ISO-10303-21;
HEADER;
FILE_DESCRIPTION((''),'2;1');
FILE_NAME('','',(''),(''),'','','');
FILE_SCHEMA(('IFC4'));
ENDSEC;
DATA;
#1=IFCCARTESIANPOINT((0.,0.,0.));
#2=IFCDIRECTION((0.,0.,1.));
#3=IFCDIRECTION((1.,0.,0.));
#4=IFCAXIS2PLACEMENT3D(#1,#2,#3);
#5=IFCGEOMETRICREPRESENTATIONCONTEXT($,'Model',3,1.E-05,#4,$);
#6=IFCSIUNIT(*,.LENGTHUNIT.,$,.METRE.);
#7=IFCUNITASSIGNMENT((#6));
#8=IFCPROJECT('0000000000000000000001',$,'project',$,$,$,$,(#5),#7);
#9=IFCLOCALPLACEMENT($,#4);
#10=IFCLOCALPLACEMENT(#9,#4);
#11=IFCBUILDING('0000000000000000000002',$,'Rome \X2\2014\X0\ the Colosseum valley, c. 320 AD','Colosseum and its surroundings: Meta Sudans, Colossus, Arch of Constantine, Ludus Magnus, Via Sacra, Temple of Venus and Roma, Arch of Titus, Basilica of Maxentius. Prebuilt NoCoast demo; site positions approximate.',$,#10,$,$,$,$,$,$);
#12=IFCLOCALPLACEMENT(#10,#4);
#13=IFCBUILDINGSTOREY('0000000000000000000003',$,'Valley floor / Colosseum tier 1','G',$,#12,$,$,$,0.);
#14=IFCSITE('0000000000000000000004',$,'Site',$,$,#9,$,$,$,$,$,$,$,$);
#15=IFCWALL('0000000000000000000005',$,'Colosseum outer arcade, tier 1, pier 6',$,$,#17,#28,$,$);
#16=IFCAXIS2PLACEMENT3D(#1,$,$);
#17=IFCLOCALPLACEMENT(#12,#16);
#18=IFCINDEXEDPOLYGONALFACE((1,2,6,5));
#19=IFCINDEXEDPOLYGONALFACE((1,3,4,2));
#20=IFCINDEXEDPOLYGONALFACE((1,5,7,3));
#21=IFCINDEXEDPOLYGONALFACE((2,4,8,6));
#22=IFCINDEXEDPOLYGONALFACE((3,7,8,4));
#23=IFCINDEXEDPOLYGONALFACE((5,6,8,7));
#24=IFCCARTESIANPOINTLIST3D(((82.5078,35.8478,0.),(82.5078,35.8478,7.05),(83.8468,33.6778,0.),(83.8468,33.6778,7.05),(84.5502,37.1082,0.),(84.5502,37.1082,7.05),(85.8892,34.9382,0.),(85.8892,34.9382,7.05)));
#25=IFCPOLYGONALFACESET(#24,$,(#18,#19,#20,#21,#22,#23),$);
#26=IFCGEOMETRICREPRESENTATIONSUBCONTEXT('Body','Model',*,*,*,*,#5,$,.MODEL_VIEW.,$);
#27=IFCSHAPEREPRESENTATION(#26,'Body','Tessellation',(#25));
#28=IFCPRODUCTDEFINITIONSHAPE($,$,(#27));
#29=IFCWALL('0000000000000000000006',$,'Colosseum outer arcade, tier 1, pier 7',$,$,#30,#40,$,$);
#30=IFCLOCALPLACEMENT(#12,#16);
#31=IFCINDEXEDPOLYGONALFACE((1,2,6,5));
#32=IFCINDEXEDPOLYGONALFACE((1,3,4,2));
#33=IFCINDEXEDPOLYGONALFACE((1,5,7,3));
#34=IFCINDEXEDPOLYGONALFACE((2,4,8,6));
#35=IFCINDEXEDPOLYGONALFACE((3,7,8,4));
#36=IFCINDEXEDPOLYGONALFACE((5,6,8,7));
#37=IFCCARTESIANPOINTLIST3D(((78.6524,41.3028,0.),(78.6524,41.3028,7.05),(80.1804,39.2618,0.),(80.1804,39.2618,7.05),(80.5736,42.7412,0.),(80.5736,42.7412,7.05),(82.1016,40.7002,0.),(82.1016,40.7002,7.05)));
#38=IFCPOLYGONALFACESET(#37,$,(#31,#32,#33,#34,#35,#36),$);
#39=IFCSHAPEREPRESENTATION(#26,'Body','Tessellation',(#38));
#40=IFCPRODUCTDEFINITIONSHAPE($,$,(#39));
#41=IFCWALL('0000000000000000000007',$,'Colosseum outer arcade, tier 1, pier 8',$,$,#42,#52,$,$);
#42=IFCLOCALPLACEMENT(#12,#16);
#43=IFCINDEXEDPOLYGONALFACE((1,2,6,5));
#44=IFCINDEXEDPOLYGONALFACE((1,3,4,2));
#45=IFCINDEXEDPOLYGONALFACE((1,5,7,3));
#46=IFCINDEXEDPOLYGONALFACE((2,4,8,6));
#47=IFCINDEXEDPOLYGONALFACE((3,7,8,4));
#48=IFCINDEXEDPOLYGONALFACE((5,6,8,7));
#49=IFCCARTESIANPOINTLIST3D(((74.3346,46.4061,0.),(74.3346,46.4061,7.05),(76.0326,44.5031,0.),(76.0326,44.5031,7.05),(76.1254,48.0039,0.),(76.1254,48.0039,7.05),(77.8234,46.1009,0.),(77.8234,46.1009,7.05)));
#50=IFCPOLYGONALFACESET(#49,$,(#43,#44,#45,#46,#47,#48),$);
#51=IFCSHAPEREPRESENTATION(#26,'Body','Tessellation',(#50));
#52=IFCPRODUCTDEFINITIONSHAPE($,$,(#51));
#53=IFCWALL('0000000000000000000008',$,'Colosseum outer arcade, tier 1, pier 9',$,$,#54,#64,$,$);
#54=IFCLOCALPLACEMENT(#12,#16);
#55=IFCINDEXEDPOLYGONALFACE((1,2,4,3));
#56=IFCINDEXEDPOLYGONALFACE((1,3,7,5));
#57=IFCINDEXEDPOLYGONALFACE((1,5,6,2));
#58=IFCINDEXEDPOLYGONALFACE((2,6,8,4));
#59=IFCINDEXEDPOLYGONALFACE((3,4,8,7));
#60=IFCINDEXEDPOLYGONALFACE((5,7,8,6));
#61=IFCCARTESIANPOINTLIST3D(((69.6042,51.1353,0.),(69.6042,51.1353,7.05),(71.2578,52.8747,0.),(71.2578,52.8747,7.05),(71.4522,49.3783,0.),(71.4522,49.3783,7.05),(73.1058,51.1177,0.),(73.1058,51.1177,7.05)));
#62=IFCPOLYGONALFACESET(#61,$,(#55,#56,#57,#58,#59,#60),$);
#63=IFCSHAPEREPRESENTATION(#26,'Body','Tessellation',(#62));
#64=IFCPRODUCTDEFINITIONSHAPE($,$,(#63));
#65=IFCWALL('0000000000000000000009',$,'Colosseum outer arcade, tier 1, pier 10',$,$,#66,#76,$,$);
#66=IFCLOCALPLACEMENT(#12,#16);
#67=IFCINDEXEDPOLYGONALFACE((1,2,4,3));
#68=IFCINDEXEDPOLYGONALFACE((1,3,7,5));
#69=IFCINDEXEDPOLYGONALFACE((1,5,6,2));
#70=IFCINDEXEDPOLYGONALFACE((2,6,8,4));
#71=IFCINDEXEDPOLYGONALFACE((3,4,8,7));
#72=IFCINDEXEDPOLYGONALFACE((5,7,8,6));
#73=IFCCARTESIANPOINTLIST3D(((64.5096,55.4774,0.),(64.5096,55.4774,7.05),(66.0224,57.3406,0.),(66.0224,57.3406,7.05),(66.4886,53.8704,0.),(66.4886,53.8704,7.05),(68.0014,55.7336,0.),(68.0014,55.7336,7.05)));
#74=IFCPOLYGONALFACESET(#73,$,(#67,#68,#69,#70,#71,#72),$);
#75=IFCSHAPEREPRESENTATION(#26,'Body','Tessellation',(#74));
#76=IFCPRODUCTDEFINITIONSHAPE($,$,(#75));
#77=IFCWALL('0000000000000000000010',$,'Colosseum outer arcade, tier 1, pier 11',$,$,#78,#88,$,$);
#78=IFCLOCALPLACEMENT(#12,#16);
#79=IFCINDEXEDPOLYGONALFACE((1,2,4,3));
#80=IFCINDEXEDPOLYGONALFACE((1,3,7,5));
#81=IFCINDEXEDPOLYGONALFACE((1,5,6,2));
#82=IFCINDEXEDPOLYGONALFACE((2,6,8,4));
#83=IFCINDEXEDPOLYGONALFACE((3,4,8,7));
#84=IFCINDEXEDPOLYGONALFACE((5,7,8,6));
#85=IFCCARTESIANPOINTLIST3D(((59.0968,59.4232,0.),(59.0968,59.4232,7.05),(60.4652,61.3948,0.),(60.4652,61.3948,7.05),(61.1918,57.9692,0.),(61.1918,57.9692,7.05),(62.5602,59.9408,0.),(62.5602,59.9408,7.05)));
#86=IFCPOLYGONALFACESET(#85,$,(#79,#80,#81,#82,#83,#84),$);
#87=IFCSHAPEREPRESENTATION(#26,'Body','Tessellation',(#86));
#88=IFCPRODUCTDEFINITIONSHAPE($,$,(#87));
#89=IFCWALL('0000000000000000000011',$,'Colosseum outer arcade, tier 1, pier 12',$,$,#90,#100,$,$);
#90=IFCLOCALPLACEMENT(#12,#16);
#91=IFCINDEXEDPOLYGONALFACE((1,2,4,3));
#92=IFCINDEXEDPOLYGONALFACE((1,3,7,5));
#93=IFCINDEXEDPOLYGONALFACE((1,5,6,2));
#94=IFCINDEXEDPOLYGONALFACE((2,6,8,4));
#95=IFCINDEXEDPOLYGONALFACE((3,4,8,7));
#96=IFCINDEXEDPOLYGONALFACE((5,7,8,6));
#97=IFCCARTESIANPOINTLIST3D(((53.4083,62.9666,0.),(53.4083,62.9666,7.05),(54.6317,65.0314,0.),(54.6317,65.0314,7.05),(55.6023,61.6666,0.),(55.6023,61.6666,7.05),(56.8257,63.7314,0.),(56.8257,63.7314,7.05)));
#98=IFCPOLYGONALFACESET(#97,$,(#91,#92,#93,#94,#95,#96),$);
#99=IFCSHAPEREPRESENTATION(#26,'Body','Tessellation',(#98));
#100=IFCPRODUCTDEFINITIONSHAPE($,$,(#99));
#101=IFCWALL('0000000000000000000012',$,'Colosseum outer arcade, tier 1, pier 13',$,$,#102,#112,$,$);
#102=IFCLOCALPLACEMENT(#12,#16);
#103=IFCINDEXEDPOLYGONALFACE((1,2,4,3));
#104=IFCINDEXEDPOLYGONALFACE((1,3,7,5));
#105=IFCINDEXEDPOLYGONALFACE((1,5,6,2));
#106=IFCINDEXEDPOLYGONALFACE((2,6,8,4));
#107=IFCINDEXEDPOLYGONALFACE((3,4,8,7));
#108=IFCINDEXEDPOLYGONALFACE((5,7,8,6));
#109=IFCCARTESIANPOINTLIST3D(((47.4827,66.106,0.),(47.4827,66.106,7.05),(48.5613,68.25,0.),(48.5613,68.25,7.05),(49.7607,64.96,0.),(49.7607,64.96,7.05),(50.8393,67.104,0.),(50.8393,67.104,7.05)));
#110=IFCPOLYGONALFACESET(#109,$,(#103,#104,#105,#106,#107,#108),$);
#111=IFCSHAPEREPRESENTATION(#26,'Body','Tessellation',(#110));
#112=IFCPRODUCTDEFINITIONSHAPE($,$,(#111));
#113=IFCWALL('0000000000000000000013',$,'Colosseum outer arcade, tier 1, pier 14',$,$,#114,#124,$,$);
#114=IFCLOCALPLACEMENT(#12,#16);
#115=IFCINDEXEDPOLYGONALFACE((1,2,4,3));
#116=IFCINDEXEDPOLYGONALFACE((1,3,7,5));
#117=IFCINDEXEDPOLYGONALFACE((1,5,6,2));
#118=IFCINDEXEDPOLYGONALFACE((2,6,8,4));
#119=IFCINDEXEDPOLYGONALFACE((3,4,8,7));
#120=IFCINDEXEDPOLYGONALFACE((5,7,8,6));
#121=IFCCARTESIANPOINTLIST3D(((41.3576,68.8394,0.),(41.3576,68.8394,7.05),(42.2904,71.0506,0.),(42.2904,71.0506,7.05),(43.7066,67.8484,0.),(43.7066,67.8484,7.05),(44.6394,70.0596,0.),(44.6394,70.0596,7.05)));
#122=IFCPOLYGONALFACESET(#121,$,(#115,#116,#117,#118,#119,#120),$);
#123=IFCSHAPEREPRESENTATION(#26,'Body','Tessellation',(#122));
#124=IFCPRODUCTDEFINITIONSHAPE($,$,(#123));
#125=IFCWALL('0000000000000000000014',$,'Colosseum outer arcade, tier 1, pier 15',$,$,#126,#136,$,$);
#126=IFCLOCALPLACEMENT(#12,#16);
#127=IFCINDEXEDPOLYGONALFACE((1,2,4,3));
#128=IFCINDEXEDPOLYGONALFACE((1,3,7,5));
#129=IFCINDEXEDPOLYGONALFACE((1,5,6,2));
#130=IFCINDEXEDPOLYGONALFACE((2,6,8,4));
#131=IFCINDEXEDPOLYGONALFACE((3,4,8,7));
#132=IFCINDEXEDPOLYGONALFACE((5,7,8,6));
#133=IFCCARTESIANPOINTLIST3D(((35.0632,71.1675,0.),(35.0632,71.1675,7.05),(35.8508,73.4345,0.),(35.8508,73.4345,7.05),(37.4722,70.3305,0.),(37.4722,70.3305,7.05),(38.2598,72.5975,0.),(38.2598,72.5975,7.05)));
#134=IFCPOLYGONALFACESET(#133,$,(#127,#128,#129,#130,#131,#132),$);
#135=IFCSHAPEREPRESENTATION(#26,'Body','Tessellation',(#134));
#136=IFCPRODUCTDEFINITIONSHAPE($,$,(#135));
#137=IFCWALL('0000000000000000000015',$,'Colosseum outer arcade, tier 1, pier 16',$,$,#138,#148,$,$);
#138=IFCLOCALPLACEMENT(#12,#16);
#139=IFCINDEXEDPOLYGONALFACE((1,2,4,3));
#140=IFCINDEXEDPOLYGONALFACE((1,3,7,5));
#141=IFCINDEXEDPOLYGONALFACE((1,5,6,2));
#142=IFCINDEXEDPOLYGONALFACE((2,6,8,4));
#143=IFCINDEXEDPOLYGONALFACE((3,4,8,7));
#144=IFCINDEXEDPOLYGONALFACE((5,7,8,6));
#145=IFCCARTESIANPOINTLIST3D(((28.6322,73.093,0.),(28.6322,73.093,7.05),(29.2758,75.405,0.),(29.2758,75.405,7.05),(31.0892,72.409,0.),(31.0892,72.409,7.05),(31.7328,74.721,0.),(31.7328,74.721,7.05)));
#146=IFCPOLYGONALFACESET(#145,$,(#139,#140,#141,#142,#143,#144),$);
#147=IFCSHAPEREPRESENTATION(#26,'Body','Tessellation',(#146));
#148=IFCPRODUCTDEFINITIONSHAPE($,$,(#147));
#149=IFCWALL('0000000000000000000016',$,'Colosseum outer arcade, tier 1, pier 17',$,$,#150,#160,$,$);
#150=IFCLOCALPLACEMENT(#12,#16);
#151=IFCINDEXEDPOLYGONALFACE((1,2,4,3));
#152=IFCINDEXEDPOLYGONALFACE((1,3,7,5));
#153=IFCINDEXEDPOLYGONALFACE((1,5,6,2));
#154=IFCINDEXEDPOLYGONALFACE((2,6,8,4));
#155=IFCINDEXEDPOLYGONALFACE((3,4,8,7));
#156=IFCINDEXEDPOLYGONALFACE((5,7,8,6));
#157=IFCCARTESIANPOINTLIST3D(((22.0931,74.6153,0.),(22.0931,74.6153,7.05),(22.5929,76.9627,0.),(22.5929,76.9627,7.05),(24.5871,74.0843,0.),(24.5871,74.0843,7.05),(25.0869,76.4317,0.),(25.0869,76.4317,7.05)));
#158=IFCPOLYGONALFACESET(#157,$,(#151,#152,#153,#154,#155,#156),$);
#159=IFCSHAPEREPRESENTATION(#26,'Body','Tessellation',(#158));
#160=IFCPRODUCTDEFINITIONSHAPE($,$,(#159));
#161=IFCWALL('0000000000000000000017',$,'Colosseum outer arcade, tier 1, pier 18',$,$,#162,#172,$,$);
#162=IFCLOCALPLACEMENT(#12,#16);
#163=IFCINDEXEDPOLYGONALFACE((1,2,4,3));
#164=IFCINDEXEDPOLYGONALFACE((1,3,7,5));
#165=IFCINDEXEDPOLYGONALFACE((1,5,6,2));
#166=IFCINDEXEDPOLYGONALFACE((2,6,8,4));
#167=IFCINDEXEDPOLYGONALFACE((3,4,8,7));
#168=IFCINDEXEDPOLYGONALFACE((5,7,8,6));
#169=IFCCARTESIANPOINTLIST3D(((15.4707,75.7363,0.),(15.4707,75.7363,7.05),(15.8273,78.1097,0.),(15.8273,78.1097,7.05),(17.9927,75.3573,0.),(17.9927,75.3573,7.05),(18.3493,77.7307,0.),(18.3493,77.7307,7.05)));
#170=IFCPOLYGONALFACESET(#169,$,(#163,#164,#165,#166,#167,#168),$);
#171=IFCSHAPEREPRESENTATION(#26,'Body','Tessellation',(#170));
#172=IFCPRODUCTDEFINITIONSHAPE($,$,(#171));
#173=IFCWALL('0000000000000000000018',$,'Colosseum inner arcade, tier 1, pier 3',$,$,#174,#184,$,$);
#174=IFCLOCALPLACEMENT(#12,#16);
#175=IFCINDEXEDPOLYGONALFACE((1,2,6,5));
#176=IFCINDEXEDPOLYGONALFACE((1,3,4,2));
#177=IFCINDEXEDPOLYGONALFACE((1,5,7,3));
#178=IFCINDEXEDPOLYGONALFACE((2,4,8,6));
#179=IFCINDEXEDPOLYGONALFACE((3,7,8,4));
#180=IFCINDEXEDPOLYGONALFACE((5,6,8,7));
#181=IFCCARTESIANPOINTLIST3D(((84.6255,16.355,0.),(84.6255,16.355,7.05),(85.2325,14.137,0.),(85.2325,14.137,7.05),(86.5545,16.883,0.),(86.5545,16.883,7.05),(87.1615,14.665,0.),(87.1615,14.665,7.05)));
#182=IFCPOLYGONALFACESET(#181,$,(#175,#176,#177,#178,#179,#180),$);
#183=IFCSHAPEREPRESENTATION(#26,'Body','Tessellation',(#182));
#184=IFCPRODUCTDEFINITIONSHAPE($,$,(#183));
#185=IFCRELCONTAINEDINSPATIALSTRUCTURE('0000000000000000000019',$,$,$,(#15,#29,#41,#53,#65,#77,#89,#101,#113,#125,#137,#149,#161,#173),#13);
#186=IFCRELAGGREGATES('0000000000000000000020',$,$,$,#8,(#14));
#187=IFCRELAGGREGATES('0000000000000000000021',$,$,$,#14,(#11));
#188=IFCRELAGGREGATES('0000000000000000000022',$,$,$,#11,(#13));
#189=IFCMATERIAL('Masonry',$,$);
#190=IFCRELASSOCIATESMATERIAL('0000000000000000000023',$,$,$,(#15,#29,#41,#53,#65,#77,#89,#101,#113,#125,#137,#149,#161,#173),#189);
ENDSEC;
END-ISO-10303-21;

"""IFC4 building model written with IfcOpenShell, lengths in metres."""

from ifc_helpers import new_model, si_unit, frame, origin_with_axes, place, context, subcontext, project, spatial, indexed_curve, outline, extrude, material, element, save


model = new_model("IFC4")

# Units and contexts
model_context = context("Model", 3, precision=1e-05, world=origin_with_axes())
body_context = subcontext(model_context, "Body", "Model", "MODEL_VIEW")
ifc_project = project(units=[si_unit("LENGTHUNIT", "METRE")], contexts=[model_context])

# Site, building, storey
site_placement = place(None, origin_with_axes())
site = spatial("IfcSite", under=ifc_project, at=site_placement, Name="Site")
building_placement = place(site_placement, origin_with_axes())
building = spatial("IfcBuilding", under=site, at=building_placement, Name="Rome — the Colosseum valley, c. 320 AD", Description="Colosseum and its surroundings: Meta Sudans, Colossus, Arch of Constantine, Ludus Magnus, Via Sacra, Temple of Venus and Roma, Arch of Titus, Basilica of Maxentius. Prebuilt NoCoast demo; site positions approximate.")
storey_placement = place(building_placement, origin_with_axes())
storey = spatial("IfcBuildingStorey", under=building, at=storey_placement, Name="Valley floor / Colosseum tier 1", Description="G", Elevation=0.0)

# Walls
ifc_material = material(Name="Masonry")
wall_1_placement = place(storey_placement, frame((84.868, 34.308, 0.0), z_axis=(0.0, 0.0, 1.0), x_axis=(-0.525125, 0.851025, 0.0)))
element("IfcWall", 1, at=wall_1_placement, inside=storey, material=ifc_material, Name="Colosseum outer arcade, tier 1, pier 6", context=body_context, shape_type="SweptSolid", body=[
    extrude(outline(indexed_curve([(0.0, 0.0), (0.0, 2.4), (2.5499, 2.4), (2.5499, 0.0), (0.0, 0.0)], self_intersect=False)), frame((0.0, -1.2, 0.0), z_axis=(0.0, 0.0, 1.0), x_axis=(1.0, 0.0, 0.0)), (0.0, 0.0, 1.0), 7.05),
])
wall_2_placement = place(storey_placement, frame((81.141, 39.981, 0.0), z_axis=(0.0, 0.0, 1.0), x_axis=(-0.599309, 0.800517, 0.0)))
element("IfcWall", 2, at=wall_2_placement, inside=storey, material=ifc_material, Name="Colosseum outer arcade, tier 1, pier 7", context=body_context, shape_type="SweptSolid", body=[
    extrude(outline(indexed_curve([(0.0, 0.0), (0.0, 2.4), (2.5496, 2.4), (2.5496, 0.0), (0.0, 0.0)], self_intersect=False)), frame((0.0, -1.2, 0.0), z_axis=(0.0, 0.0, 1.0), x_axis=(1.0, 0.0, 0.0)), (0.0, 0.0, 1.0), 7.05),
])
wall_3_placement = place(storey_placement, frame((76.928, 45.302, 0.0), z_axis=(0.0, 0.0, 1.0), x_axis=(-0.665774, 0.746153, 0.0)))
element("IfcWall", 3, at=wall_3_placement, inside=storey, material=ifc_material, Name="Colosseum outer arcade, tier 1, pier 8", context=body_context, shape_type="SweptSolid", body=[
    extrude(outline(indexed_curve([(0.0, 0.0), (0.0, 2.4), (2.5504, 2.4), (2.5504, 0.0), (0.0, 0.0)], self_intersect=False)), frame((0.0, -1.2, 0.0), z_axis=(0.0, 0.0, 1.0), x_axis=(1.0, 0.0, 0.0)), (0.0, 0.0, 1.0), 7.05),
])
wall_4_placement = place(storey_placement, frame((72.279, 50.248, 0.0), z_axis=(0.0, 0.0, 1.0), x_axis=(-0.724725, 0.689038, 0.0)))
element("IfcWall", 4, at=wall_4_placement, inside=storey, material=ifc_material, Name="Colosseum outer arcade, tier 1, pier 9", context=body_context, shape_type="SweptSolid", body=[
    extrude(outline(indexed_curve([(0.0, 0.0), (0.0, 2.4), (2.5499, 2.4), (2.5499, 0.0), (0.0, 0.0)], self_intersect=False)), frame((0.0, -1.2, 0.0), z_axis=(0.0, 0.0, 1.0), x_axis=(1.0, 0.0, 0.0)), (0.0, 0.0, 1.0), 7.05),
])
wall_5_placement = place(storey_placement, frame((67.245, 54.802, 0.0), z_axis=(0.0, 0.0, 1.0), x_axis=(-0.776294, 0.630371, 0.0)))
element("IfcWall", 5, at=wall_5_placement, inside=storey, material=ifc_material, Name="Colosseum outer arcade, tier 1, pier 10", context=body_context, shape_type="SweptSolid", body=[
    extrude(outline(indexed_curve([(0.0, 0.0), (0.0, 2.4), (2.5493, 2.4), (2.5493, 0.0), (0.0, 0.0)], self_intersect=False)), frame((0.0, -1.2, 0.0), z_axis=(0.0, 0.0, 1.0), x_axis=(1.0, 0.0, 0.0)), (0.0, 0.0, 1.0), 7.05),
])
wall_6_placement = place(storey_placement, frame((61.876, 58.955, 0.0), z_axis=(0.0, 0.0, 1.0), x_axis=(-0.821528, 0.570168, 0.0)))
element("IfcWall", 6, at=wall_6_placement, inside=storey, material=ifc_material, Name="Colosseum outer arcade, tier 1, pier 11", context=body_context, shape_type="SweptSolid", body=[
    extrude(outline(indexed_curve([(0.0, 0.0), (0.0, 2.4), (2.5501, 2.4), (2.5501, 0.0), (0.0, 0.0)], self_intersect=False)), frame((0.0, -1.2, 0.0), z_axis=(0.0, 0.0, 1.0), x_axis=(1.0, 0.0, 0.0)), (0.0, 0.0, 1.0), 7.05),
])
wall_7_placement = place(storey_placement, frame((56.214, 62.699, 0.0), z_axis=(0.0, 0.0, 1.0), x_axis=(-0.860317, 0.509759, 0.0)))
element("IfcWall", 7, at=wall_7_placement, inside=storey, material=ifc_material, Name="Colosseum outer arcade, tier 1, pier 12", context=body_context, shape_type="SweptSolid", body=[
    extrude(outline(indexed_curve([(0.0, 0.0), (0.0, 2.4), (2.5502, 2.4), (2.5502, 0.0), (0.0, 0.0)], self_intersect=False)), frame((0.0, -1.2, 0.0), z_axis=(0.0, 0.0, 1.0), x_axis=(1.0, 0.0, 0.0)), (0.0, 0.0, 1.0), 7.05),
])
wall_8_placement = place(storey_placement, frame((50.3, 66.032, 0.0), z_axis=(0.0, 0.0, 1.0), x_axis=(-0.893326, 0.449408, 0.0)))
element("IfcWall", 8, at=wall_8_placement, inside=storey, material=ifc_material, Name="Colosseum outer arcade, tier 1, pier 13", context=body_context, shape_type="SweptSolid", body=[
    extrude(outline(indexed_curve([(0.0, 0.0), (0.0, 2.4), (2.55, 2.4), (2.55, 0.0), (0.0, 0.0)], self_intersect=False)), frame((0.0, -1.2, 0.0), z_axis=(0.0, 0.0, 1.0), x_axis=(1.0, 0.0, 0.0)), (0.0, 0.0, 1.0), 7.05),
])
wall_9_placement = place(storey_placement, frame((44.173, 68.954, 0.0), z_axis=(0.0, 0.0, 1.0), x_axis=(-0.921362, 0.388706, 0.0)))
element("IfcWall", 9, at=wall_9_placement, inside=storey, material=ifc_material, Name="Colosseum outer arcade, tier 1, pier 14", context=body_context, shape_type="SweptSolid", body=[
    extrude(outline(indexed_curve([(0.0, 0.0), (0.0, 2.4), (2.5495, 2.4), (2.5495, 0.0), (0.0, 0.0)], self_intersect=False)), frame((0.0, -1.2, 0.0), z_axis=(0.0, 0.0, 1.0), x_axis=(1.0, 0.0, 0.0)), (0.0, 0.0, 1.0), 7.05),
])
wall_10_placement = place(storey_placement, frame((37.866, 71.464, 0.0), z_axis=(0.0, 0.0, 1.0), x_axis=(-0.944608, 0.328201, 0.0)))
element("IfcWall", 10, at=wall_10_placement, inside=storey, material=ifc_material, Name="Colosseum outer arcade, tier 1, pier 15", context=body_context, shape_type="SweptSolid", body=[
    extrude(outline(indexed_curve([(0.0, 0.0), (0.0, 2.4), (2.5503, 2.4), (2.5503, 0.0), (0.0, 0.0)], self_intersect=False)), frame((0.0, -1.2, 0.0), z_axis=(0.0, 0.0, 1.0), x_axis=(1.0, 0.0, 0.0)), (0.0, 0.0, 1.0), 7.05),
])
wall_11_placement = place(storey_placement, frame((31.411, 73.565, 0.0), z_axis=(0.0, 0.0, 1.0), x_axis=(-0.963366, 0.26819, 0.0)))
element("IfcWall", 11, at=wall_11_placement, inside=storey, material=ifc_material, Name="Colosseum outer arcade, tier 1, pier 16", context=body_context, shape_type="SweptSolid", body=[
    extrude(outline(indexed_curve([(0.0, 0.0), (0.0, 2.4), (2.5504, 2.4), (2.5504, 0.0), (0.0, 0.0)], self_intersect=False)), frame((0.0, -1.2, 0.0), z_axis=(0.0, 0.0, 1.0), x_axis=(1.0, 0.0, 0.0)), (0.0, 0.0, 1.0), 7.05),
])
wall_12_placement = place(storey_placement, frame((24.837, 75.258, 0.0), z_axis=(0.0, 0.0, 1.0), x_axis=(-0.978077, 0.208243, 0.0)))
element("IfcWall", 12, at=wall_12_placement, inside=storey, material=ifc_material, Name="Colosseum outer arcade, tier 1, pier 17", context=body_context, shape_type="SweptSolid", body=[
    extrude(outline(indexed_curve([(0.0, 0.0), (0.0, 2.4), (2.5499, 2.4), (2.5499, 0.0), (0.0, 0.0)], self_intersect=False)), frame((0.0, -1.2, 0.0), z_axis=(0.0, 0.0, 1.0), x_axis=(1.0, 0.0, 0.0)), (0.0, 0.0, 1.0), 7.05),
])
wall_13_placement = place(storey_placement, frame((18.171, 76.544, 0.0), z_axis=(0.0, 0.0, 1.0), x_axis=(-0.988896, 0.148609, 0.0)))
element("IfcWall", 13, at=wall_13_placement, inside=storey, material=ifc_material, Name="Colosseum outer arcade, tier 1, pier 18", context=body_context, shape_type="SweptSolid", body=[
    extrude(outline(indexed_curve([(0.0, 0.0), (0.0, 2.4), (2.5503, 2.4), (2.5503, 0.0), (0.0, 0.0)], self_intersect=False)), frame((0.0, -1.2, 0.0), z_axis=(0.0, 0.0, 1.0), x_axis=(1.0, 0.0, 0.0)), (0.0, 0.0, 1.0), 7.05),
])
wall_14_placement = place(storey_placement, frame((86.197, 14.401, 0.0), z_axis=(0.0, 0.0, 1.0), x_axis=(-0.263964, 0.964533, 0.0)))
element("IfcWall", 14, at=wall_14_placement, inside=storey, material=ifc_material, Name="Colosseum inner arcade, tier 1, pier 3", context=body_context, shape_type="SweptSolid", body=[
    extrude(outline(indexed_curve([(0.0, 0.0), (0.0, 2.0), (2.2996, 2.0), (2.2996, 0.0), (0.0, 0.0)], self_intersect=False)), frame((0.0, -1.0, 0.0), z_axis=(0.0, 0.0, 1.0), x_axis=(1.0, 0.0, 0.0)), (0.0, 0.0, 1.0), 7.05),
])

save(model, "model.ifc")
